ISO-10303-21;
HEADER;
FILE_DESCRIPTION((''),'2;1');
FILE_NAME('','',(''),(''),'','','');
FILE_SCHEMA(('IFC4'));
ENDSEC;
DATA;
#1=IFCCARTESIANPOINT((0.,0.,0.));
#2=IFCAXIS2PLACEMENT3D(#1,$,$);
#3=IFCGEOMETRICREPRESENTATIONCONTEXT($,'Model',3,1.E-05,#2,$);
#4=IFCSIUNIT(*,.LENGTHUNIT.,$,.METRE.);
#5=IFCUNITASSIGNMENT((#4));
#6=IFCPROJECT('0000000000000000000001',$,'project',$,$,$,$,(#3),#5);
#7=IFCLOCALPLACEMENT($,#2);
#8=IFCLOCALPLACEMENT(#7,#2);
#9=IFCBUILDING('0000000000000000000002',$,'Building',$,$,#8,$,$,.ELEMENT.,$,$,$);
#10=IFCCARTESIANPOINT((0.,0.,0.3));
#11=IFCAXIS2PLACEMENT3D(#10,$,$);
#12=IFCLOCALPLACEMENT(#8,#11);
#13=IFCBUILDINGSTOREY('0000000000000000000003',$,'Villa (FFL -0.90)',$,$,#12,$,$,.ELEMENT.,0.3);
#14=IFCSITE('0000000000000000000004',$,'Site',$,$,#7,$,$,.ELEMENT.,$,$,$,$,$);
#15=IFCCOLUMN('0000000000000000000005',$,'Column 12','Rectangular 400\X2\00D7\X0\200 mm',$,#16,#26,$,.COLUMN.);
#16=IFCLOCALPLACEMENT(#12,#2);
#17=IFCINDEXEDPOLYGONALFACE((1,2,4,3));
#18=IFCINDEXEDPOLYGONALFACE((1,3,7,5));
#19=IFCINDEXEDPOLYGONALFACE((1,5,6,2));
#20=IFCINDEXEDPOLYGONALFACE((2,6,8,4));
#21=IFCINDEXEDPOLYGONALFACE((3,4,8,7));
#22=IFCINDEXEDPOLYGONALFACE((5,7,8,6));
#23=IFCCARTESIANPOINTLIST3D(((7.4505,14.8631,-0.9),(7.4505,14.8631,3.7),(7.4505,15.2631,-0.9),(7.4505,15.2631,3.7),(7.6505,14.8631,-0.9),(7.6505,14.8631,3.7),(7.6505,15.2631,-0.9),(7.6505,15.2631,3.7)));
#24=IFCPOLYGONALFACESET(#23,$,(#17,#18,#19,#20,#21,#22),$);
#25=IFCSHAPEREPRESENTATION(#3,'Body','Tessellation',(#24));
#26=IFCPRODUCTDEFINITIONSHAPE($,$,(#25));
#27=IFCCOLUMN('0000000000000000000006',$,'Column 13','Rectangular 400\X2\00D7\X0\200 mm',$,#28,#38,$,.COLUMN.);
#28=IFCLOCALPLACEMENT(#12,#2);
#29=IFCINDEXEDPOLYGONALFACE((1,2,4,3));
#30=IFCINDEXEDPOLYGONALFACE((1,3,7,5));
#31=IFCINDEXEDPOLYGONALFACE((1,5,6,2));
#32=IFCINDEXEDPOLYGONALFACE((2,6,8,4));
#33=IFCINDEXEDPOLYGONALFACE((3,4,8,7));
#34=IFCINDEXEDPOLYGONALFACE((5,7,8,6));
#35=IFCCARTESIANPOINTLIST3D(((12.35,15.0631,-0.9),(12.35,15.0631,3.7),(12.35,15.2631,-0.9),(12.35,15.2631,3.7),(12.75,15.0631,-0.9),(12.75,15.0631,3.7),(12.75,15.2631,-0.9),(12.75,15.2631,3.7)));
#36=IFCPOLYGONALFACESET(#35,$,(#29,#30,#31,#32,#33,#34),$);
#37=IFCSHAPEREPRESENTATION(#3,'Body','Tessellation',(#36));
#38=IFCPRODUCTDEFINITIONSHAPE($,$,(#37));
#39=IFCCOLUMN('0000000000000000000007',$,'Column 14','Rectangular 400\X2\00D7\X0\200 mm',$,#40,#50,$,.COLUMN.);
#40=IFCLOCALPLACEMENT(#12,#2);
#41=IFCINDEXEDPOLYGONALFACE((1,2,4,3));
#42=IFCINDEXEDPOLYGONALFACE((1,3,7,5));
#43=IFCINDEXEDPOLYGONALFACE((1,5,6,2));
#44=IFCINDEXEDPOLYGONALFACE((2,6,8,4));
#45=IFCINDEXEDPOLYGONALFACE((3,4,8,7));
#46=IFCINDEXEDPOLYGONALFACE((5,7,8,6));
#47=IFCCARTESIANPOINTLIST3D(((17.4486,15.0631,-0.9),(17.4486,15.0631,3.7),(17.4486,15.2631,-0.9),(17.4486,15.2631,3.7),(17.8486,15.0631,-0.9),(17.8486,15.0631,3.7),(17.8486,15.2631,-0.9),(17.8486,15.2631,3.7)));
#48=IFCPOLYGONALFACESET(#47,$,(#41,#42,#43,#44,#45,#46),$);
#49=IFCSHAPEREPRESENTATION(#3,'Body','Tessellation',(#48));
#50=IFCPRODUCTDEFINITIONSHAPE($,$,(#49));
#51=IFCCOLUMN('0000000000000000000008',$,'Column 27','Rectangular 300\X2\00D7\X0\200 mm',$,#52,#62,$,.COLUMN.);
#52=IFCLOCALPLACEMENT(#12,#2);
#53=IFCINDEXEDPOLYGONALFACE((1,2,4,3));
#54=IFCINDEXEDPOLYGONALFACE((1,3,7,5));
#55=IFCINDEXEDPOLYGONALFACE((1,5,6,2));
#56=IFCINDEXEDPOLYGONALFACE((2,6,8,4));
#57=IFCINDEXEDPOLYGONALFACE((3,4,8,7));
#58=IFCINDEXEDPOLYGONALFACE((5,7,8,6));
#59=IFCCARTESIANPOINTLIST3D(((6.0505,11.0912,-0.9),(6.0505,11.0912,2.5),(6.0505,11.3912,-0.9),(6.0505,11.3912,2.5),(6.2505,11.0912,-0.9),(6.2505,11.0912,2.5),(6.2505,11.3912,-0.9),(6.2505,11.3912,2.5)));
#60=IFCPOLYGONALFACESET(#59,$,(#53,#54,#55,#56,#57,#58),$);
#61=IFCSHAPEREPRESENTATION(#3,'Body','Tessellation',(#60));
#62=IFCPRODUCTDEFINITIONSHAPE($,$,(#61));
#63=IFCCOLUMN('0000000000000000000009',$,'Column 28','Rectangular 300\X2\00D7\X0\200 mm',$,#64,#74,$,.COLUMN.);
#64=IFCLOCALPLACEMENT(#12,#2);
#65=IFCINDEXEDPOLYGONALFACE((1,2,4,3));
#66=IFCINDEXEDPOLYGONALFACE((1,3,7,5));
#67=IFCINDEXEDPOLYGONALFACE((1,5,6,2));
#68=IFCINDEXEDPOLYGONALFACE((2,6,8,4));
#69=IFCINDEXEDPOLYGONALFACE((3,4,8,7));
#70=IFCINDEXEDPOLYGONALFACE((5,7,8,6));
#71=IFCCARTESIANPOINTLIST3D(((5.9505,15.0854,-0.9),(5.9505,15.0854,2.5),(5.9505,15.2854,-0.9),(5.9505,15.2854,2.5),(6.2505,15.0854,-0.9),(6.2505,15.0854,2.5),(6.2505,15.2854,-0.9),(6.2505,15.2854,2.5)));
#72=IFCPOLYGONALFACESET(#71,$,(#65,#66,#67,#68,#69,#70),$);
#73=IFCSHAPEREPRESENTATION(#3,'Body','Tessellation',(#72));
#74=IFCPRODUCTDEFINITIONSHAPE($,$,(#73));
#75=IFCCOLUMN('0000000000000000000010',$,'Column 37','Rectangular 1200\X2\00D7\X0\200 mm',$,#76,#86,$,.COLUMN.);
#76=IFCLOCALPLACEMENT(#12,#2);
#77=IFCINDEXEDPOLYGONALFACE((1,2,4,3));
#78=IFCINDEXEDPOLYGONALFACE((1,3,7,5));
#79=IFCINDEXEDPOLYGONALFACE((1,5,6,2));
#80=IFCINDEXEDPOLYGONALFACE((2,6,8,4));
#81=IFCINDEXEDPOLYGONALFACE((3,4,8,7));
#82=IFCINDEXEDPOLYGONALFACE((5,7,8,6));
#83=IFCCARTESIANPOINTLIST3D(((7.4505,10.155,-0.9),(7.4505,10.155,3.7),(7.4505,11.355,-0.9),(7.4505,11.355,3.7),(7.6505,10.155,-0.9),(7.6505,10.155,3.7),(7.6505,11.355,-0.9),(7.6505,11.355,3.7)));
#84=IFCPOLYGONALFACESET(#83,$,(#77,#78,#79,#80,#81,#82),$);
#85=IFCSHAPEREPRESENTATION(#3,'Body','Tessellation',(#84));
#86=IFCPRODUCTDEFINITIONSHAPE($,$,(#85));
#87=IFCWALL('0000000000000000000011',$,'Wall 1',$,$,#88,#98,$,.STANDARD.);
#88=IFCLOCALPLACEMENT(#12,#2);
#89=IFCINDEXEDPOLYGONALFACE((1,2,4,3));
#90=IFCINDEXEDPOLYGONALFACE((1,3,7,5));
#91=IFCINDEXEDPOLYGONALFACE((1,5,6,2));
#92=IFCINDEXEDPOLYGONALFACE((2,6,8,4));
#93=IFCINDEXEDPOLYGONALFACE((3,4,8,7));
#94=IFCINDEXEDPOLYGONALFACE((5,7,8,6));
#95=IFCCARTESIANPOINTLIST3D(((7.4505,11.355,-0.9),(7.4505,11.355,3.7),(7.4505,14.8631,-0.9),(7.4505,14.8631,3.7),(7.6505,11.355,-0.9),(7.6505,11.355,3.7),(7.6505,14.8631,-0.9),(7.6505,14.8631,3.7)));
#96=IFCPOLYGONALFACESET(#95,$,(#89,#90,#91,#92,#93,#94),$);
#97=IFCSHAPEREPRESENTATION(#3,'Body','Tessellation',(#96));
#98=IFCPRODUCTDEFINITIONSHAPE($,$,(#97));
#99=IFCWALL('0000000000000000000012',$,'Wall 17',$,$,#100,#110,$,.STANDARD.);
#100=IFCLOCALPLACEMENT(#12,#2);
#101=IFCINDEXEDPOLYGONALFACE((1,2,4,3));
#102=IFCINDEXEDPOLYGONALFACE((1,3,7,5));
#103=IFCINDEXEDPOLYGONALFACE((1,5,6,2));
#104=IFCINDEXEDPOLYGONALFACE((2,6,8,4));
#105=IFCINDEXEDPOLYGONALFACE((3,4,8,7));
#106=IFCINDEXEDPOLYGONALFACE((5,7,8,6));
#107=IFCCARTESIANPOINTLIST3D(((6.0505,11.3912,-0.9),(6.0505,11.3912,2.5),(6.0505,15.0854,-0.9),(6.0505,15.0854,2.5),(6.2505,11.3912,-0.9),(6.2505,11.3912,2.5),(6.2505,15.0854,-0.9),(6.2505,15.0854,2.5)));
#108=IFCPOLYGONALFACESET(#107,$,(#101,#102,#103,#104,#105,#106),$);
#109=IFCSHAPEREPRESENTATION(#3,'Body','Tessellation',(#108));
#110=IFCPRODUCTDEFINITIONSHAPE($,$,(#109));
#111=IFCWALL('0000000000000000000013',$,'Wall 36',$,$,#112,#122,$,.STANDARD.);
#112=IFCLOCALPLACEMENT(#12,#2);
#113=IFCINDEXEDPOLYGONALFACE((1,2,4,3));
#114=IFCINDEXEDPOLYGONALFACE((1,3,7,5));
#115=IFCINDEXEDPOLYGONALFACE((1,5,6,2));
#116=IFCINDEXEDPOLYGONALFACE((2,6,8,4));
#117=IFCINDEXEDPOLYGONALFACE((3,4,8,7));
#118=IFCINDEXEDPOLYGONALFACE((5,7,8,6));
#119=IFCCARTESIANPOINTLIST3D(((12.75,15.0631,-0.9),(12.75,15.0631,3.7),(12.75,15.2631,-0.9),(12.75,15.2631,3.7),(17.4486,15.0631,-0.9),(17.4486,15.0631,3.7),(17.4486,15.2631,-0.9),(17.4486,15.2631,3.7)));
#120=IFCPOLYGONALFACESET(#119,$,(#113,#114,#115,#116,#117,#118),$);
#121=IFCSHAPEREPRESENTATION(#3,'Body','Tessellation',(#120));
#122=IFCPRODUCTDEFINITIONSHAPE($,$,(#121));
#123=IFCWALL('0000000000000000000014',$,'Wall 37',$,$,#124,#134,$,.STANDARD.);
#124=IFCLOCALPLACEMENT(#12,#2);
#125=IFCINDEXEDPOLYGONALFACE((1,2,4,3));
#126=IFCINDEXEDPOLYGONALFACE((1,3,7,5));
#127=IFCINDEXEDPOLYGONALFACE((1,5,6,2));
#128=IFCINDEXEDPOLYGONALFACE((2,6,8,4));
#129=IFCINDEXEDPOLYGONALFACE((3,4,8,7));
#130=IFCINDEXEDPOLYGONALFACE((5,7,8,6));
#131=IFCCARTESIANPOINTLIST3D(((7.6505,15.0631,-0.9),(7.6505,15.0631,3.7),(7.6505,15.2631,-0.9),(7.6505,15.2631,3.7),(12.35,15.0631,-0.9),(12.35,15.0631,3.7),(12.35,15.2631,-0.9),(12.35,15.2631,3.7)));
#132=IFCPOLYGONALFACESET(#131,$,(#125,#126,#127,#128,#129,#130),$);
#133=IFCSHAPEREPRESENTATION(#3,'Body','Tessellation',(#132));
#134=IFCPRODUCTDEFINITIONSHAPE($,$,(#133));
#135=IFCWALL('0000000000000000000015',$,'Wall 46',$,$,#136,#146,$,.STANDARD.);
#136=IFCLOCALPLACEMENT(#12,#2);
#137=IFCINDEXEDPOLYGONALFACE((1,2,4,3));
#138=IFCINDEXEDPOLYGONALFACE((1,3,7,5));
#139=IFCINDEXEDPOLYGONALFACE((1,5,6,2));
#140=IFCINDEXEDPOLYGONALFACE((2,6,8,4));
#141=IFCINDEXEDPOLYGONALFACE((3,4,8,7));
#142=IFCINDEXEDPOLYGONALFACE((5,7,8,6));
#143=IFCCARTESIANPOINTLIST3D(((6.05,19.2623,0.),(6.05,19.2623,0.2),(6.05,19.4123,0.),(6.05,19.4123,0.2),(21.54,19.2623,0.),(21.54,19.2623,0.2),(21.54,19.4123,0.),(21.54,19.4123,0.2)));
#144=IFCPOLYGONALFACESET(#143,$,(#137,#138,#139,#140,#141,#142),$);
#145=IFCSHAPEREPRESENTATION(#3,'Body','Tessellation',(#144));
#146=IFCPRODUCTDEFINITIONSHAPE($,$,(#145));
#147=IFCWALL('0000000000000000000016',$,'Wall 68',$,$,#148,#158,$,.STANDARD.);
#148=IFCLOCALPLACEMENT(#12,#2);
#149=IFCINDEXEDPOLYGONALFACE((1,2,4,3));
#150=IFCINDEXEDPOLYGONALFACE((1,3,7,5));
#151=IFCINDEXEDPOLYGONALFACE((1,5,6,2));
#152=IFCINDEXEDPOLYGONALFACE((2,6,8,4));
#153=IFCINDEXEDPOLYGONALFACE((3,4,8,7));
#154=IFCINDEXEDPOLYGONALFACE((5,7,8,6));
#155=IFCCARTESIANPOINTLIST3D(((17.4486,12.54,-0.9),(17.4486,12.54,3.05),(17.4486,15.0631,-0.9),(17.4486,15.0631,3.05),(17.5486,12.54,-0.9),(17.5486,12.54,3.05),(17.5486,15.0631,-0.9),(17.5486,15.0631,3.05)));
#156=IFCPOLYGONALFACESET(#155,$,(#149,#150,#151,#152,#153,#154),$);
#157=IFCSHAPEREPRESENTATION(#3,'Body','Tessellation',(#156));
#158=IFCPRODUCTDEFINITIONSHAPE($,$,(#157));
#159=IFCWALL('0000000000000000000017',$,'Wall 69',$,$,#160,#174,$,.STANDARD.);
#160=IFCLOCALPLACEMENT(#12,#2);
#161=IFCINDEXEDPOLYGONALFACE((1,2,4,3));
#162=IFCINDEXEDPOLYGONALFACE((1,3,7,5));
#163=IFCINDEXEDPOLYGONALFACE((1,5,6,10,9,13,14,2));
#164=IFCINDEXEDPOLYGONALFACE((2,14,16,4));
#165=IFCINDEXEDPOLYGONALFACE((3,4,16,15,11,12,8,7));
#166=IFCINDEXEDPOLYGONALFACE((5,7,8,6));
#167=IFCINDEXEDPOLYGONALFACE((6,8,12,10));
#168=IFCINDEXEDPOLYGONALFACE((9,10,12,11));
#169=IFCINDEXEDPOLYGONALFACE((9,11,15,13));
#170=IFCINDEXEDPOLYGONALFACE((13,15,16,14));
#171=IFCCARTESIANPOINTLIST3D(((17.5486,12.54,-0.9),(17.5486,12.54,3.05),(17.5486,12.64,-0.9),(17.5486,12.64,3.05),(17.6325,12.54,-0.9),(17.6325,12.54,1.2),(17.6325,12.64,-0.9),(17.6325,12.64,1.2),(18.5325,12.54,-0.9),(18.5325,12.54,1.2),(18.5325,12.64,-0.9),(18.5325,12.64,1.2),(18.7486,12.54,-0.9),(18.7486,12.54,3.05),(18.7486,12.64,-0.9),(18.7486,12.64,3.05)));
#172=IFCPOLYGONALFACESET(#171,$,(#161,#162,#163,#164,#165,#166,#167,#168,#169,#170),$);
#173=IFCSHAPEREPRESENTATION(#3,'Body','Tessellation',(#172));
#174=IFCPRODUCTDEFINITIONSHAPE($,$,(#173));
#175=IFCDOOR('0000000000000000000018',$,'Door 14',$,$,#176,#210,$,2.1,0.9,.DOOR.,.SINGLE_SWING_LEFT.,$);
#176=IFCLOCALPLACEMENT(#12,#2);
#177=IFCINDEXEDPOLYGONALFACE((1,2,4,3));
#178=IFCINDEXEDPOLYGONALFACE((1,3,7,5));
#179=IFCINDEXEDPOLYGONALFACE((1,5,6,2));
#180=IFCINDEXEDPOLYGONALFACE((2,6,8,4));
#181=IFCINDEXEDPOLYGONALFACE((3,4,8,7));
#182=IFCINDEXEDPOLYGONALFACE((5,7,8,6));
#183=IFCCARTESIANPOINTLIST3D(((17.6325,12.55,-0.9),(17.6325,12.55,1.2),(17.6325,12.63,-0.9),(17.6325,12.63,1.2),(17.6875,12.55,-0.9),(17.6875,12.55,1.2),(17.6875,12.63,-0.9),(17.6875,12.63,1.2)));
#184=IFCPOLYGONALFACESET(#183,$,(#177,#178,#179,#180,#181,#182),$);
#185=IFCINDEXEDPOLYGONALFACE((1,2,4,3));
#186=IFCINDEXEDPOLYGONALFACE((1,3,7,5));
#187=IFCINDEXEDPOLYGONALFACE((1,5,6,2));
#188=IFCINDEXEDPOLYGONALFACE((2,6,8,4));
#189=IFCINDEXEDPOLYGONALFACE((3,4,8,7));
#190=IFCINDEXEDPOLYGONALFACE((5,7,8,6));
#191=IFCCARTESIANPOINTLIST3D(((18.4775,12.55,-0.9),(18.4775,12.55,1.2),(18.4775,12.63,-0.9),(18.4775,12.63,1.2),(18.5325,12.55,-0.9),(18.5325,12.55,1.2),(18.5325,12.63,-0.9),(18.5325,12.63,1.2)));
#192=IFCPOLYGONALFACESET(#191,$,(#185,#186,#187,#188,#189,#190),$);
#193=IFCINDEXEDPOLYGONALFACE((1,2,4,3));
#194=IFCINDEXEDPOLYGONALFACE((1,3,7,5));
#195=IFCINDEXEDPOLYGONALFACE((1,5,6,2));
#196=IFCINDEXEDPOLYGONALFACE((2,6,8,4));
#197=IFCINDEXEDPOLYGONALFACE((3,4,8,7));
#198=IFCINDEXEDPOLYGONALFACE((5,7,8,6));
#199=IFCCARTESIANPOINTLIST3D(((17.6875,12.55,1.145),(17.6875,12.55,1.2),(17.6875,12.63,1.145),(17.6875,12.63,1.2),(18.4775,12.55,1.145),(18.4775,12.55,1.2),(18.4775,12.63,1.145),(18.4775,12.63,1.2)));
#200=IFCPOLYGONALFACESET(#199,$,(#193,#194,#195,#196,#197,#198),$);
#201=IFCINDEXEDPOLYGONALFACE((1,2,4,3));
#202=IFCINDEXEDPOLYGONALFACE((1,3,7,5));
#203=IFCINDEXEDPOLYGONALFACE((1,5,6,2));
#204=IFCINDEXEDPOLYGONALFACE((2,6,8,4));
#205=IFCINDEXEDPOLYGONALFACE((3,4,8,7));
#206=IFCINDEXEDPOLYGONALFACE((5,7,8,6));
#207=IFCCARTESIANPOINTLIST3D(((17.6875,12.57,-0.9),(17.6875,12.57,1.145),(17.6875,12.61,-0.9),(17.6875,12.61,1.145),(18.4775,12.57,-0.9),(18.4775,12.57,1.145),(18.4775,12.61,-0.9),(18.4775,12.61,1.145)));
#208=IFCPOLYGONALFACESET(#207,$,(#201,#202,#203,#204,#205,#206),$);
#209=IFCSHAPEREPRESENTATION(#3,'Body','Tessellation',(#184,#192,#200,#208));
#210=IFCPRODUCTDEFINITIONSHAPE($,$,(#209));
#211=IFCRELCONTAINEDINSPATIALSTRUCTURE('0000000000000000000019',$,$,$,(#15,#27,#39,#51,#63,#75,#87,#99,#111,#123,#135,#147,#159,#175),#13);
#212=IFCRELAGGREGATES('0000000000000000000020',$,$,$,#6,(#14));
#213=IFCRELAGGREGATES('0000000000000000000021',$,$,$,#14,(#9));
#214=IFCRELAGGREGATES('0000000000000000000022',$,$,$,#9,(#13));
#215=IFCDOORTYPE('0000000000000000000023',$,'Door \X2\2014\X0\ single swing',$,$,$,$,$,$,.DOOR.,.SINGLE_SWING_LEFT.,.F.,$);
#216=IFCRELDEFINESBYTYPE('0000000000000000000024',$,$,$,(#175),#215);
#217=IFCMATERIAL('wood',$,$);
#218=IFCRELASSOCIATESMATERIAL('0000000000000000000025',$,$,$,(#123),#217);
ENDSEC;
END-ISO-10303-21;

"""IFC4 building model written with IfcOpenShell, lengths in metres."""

from ifc_helpers import new_model, si_unit, frame, frame_2d, origin, place, context, project, spatial, polyline, rectangle, outline, extrude, material, type_object, element, fill, save


model = new_model("IFC4")

# Units and contexts
model_context = context("Model", 3, precision=1e-05, world=origin())
ifc_project = project(units=[si_unit("LENGTHUNIT", "METRE")], contexts=[model_context])

# Site, building, storey
site_placement = place(None, origin())
site = spatial("IfcSite", under=ifc_project, at=site_placement, Name="Site", CompositionType="ELEMENT")
building_placement = place(site_placement, origin())
building = spatial("IfcBuilding", under=site, at=building_placement, Name="Building", CompositionType="ELEMENT")
storey_placement = place(building_placement, frame((0.0, 0.0, 0.3)))
storey = spatial("IfcBuildingStorey", under=building, at=storey_placement, Name="Villa (FFL -0.90)", CompositionType="ELEMENT", Elevation=0.3)

# Columns
for number, where, z_axis, x_axis, name in (
    (1, (7.5505, 15.0631, -0.9), (0.0, 0.0, 1.0), (0.0, 1.0, 0.0), "Column 12"),
    (2, (12.55, 15.1631, -0.9), (0.0, 0.0, 1.0), (1.0, 0.0, 0.0), "Column 13"),
    (3, (17.6486, 15.1631, -0.9), (0.0, 0.0, 1.0), (1.0, 0.0, 0.0), "Column 14"),
):
    element("IfcColumn", number, at=place(storey_placement, frame(where, z_axis=z_axis, x_axis=x_axis)), inside=storey, Name=name, Description="Rectangular 400×200 mm", PredefinedType="COLUMN", context=model_context, shape_type="SweptSolid", body=[
        extrude(outline(polyline([(-0.2, -0.1), (0.2, -0.1), (0.2, 0.1), (-0.2, 0.1), (-0.2, -0.1)])), origin(), (0.0, 0.0, 1.0), 4.6),
    ])
for number, where, z_axis, x_axis, name in (
    (4, (6.1505, 11.2412, -0.9), (0.0, 0.0, 1.0), (0.0, 1.0, 0.0), "Column 27"),
    (5, (6.1005, 15.1854, -0.9), (0.0, 0.0, 1.0), (1.0, 0.0, 0.0), "Column 28"),
):
    element("IfcColumn", number, at=place(storey_placement, frame(where, z_axis=z_axis, x_axis=x_axis)), inside=storey, Name=name, Description="Rectangular 300×200 mm", PredefinedType="COLUMN", context=model_context, shape_type="SweptSolid", body=[
        extrude(outline(polyline([(-0.15, -0.1), (0.15, -0.1), (0.15, 0.1), (-0.15, 0.1), (-0.15, -0.1)])), origin(), (0.0, 0.0, 1.0), 3.4),
    ])
column_placement = place(storey_placement, frame((7.5505, 10.755, -0.9), z_axis=(0.0, 0.0, 1.0), x_axis=(0.0, 1.0, 0.0)))
element("IfcColumn", 6, at=column_placement, inside=storey, Name="Column 37", Description="Rectangular 1200×200 mm", PredefinedType="COLUMN", context=model_context, shape_type="SweptSolid", body=[
    extrude(outline(polyline([(-0.6, -0.1), (0.6, -0.1), (0.6, 0.1), (-0.6, 0.1), (-0.6, -0.1)])), origin(), (0.0, 0.0, 1.0), 4.6),
])

# Walls
wall_1_placement = place(storey_placement, frame((7.5505, 14.8631, -0.9), z_axis=(0.0, 0.0, 1.0), x_axis=(0.0, -1.0, 0.0)))
element("IfcWall", 7, at=wall_1_placement, inside=storey, Name="Wall 1", PredefinedType="STANDARD", context=model_context, shape_type="SweptSolid", body=[
    extrude(rectangle(XDim=3.5081, YDim=0.2, at=frame_2d((1.7541, 0.0))), origin(), (0.0, 0.0, 1.0), 4.6),
])
wall_2_placement = place(storey_placement, frame((6.1505, 11.3912, -0.9), z_axis=(0.0, 0.0, 1.0), x_axis=(0.0, 1.0, 0.0)))
element("IfcWall", 8, at=wall_2_placement, inside=storey, Name="Wall 17", PredefinedType="STANDARD", context=model_context, shape_type="SweptSolid", body=[
    extrude(rectangle(XDim=3.6942, YDim=0.2, at=frame_2d((1.8471, 0.0))), origin(), (0.0, 0.0, 1.0), 3.4),
])
wall_3_placement = place(storey_placement, frame((12.75, 15.1631, -0.9), z_axis=(0.0, 0.0, 1.0), x_axis=(1.0, 0.0, 0.0)))
element("IfcWall", 9, at=wall_3_placement, inside=storey, Name="Wall 36", PredefinedType="STANDARD", context=model_context, shape_type="SweptSolid", body=[
    extrude(rectangle(XDim=4.6986, YDim=0.2, at=frame_2d((2.3493, 0.0))), origin(), (0.0, 0.0, 1.0), 4.6),
])
ifc_material = material(Name="wood")
wall_4_placement = place(storey_placement, frame((7.6505, 15.1631, -0.9), z_axis=(0.0, 0.0, 1.0), x_axis=(1.0, 0.0, 0.0)))
element("IfcWall", 10, at=wall_4_placement, inside=storey, material=ifc_material, Name="Wall 37", PredefinedType="STANDARD", context=model_context, shape_type="SweptSolid", body=[
    extrude(rectangle(XDim=4.6995, YDim=0.2, at=frame_2d((2.3497, 0.0))), origin(), (0.0, 0.0, 1.0), 4.6),
])
wall_5_placement = place(storey_placement, frame((6.05, 19.3373, 0.0), z_axis=(0.0, 0.0, 1.0), x_axis=(1.0, 0.0, 0.0)))
element("IfcWall", 11, at=wall_5_placement, inside=storey, Name="Wall 46", PredefinedType="STANDARD", context=model_context, shape_type="SweptSolid", body=[
    extrude(rectangle(XDim=15.49, YDim=0.15, at=frame_2d((7.745, 0.0))), origin(), (0.0, 0.0, 1.0), 0.2),
])
wall_6_placement = place(storey_placement, frame((17.4986, 15.0631, -0.9), z_axis=(0.0, 0.0, 1.0), x_axis=(0.0, -1.0, 0.0)))
element("IfcWall", 12, at=wall_6_placement, inside=storey, Name="Wall 68", PredefinedType="STANDARD", context=model_context, shape_type="SweptSolid", body=[
    extrude(rectangle(XDim=2.5231, YDim=0.1, at=frame_2d((1.2616, 0.0))), origin(), (0.0, 0.0, 1.0), 3.95),
])

# Wall, opening, door
wall_7_placement = place(storey_placement, frame((17.5486, 12.59, -0.9), z_axis=(0.0, 0.0, 1.0), x_axis=(1.0, 0.0, 0.0)))
wall_7 = element("IfcWall", 13, at=wall_7_placement, inside=storey, Name="Wall 69", PredefinedType="STANDARD", context=model_context, shape_type="SweptSolid", body=[
    extrude(rectangle(XDim=1.2, YDim=0.1, at=frame_2d((0.6, 0.0))), origin(), (0.0, 0.0, 1.0), 3.95),
])
opening_placement = place(storey_placement, frame((17.6325, 12.59, -0.9), z_axis=(0.0, 0.0, 1.0), x_axis=(1.0, 0.0, 0.0)))
opening = element("IfcOpeningElement", 14, at=opening_placement, cuts=wall_7, PredefinedType="OPENING", context=model_context, shape_type="SweptSolid", body=[
    extrude(rectangle(XDim=0.9, YDim=0.16, at=frame_2d((0.45, 0.0))), origin(), (0.0, 0.0, 1.0), 2.1),
])
door_type = type_object("IfcDoorType", Name="Door — single swing", OperationType="SINGLE_SWING_LEFT", ParameterTakesPrecedence=False, PredefinedType="DOOR")
door_placement = place(storey_placement, frame((17.6325, 12.59, -0.9), z_axis=(0.0, 0.0, 1.0), x_axis=(1.0, 0.0, 0.0)))
door = element("IfcDoor", 15, at=door_placement, inside=storey, type_object=door_type, Name="Door 14", OperationType="SINGLE_SWING_LEFT", OverallHeight=2.1, OverallWidth=0.9, PredefinedType="DOOR", context=model_context, shape_type="SweptSolid", body=[
    extrude(rectangle(XDim=0.055, YDim=0.08, at=frame_2d((0.0275, 0.0))), origin(), (0.0, 0.0, 1.0), 2.1),
    extrude(rectangle(XDim=0.055, YDim=0.08, at=frame_2d((0.8725, 0.0))), origin(), (0.0, 0.0, 1.0), 2.1),
    extrude(rectangle(XDim=0.79, YDim=0.08, at=frame_2d((0.45, 0.0))), frame((0.0, 0.0, 2.045)), (0.0, 0.0, 1.0), 0.055),
    extrude(rectangle(XDim=0.79, YDim=0.04, at=frame_2d((0.45, 0.0))), origin(), (0.0, 0.0, 1.0), 2.045),
])
fill(opening, door)

save(model, "model.ifc")
